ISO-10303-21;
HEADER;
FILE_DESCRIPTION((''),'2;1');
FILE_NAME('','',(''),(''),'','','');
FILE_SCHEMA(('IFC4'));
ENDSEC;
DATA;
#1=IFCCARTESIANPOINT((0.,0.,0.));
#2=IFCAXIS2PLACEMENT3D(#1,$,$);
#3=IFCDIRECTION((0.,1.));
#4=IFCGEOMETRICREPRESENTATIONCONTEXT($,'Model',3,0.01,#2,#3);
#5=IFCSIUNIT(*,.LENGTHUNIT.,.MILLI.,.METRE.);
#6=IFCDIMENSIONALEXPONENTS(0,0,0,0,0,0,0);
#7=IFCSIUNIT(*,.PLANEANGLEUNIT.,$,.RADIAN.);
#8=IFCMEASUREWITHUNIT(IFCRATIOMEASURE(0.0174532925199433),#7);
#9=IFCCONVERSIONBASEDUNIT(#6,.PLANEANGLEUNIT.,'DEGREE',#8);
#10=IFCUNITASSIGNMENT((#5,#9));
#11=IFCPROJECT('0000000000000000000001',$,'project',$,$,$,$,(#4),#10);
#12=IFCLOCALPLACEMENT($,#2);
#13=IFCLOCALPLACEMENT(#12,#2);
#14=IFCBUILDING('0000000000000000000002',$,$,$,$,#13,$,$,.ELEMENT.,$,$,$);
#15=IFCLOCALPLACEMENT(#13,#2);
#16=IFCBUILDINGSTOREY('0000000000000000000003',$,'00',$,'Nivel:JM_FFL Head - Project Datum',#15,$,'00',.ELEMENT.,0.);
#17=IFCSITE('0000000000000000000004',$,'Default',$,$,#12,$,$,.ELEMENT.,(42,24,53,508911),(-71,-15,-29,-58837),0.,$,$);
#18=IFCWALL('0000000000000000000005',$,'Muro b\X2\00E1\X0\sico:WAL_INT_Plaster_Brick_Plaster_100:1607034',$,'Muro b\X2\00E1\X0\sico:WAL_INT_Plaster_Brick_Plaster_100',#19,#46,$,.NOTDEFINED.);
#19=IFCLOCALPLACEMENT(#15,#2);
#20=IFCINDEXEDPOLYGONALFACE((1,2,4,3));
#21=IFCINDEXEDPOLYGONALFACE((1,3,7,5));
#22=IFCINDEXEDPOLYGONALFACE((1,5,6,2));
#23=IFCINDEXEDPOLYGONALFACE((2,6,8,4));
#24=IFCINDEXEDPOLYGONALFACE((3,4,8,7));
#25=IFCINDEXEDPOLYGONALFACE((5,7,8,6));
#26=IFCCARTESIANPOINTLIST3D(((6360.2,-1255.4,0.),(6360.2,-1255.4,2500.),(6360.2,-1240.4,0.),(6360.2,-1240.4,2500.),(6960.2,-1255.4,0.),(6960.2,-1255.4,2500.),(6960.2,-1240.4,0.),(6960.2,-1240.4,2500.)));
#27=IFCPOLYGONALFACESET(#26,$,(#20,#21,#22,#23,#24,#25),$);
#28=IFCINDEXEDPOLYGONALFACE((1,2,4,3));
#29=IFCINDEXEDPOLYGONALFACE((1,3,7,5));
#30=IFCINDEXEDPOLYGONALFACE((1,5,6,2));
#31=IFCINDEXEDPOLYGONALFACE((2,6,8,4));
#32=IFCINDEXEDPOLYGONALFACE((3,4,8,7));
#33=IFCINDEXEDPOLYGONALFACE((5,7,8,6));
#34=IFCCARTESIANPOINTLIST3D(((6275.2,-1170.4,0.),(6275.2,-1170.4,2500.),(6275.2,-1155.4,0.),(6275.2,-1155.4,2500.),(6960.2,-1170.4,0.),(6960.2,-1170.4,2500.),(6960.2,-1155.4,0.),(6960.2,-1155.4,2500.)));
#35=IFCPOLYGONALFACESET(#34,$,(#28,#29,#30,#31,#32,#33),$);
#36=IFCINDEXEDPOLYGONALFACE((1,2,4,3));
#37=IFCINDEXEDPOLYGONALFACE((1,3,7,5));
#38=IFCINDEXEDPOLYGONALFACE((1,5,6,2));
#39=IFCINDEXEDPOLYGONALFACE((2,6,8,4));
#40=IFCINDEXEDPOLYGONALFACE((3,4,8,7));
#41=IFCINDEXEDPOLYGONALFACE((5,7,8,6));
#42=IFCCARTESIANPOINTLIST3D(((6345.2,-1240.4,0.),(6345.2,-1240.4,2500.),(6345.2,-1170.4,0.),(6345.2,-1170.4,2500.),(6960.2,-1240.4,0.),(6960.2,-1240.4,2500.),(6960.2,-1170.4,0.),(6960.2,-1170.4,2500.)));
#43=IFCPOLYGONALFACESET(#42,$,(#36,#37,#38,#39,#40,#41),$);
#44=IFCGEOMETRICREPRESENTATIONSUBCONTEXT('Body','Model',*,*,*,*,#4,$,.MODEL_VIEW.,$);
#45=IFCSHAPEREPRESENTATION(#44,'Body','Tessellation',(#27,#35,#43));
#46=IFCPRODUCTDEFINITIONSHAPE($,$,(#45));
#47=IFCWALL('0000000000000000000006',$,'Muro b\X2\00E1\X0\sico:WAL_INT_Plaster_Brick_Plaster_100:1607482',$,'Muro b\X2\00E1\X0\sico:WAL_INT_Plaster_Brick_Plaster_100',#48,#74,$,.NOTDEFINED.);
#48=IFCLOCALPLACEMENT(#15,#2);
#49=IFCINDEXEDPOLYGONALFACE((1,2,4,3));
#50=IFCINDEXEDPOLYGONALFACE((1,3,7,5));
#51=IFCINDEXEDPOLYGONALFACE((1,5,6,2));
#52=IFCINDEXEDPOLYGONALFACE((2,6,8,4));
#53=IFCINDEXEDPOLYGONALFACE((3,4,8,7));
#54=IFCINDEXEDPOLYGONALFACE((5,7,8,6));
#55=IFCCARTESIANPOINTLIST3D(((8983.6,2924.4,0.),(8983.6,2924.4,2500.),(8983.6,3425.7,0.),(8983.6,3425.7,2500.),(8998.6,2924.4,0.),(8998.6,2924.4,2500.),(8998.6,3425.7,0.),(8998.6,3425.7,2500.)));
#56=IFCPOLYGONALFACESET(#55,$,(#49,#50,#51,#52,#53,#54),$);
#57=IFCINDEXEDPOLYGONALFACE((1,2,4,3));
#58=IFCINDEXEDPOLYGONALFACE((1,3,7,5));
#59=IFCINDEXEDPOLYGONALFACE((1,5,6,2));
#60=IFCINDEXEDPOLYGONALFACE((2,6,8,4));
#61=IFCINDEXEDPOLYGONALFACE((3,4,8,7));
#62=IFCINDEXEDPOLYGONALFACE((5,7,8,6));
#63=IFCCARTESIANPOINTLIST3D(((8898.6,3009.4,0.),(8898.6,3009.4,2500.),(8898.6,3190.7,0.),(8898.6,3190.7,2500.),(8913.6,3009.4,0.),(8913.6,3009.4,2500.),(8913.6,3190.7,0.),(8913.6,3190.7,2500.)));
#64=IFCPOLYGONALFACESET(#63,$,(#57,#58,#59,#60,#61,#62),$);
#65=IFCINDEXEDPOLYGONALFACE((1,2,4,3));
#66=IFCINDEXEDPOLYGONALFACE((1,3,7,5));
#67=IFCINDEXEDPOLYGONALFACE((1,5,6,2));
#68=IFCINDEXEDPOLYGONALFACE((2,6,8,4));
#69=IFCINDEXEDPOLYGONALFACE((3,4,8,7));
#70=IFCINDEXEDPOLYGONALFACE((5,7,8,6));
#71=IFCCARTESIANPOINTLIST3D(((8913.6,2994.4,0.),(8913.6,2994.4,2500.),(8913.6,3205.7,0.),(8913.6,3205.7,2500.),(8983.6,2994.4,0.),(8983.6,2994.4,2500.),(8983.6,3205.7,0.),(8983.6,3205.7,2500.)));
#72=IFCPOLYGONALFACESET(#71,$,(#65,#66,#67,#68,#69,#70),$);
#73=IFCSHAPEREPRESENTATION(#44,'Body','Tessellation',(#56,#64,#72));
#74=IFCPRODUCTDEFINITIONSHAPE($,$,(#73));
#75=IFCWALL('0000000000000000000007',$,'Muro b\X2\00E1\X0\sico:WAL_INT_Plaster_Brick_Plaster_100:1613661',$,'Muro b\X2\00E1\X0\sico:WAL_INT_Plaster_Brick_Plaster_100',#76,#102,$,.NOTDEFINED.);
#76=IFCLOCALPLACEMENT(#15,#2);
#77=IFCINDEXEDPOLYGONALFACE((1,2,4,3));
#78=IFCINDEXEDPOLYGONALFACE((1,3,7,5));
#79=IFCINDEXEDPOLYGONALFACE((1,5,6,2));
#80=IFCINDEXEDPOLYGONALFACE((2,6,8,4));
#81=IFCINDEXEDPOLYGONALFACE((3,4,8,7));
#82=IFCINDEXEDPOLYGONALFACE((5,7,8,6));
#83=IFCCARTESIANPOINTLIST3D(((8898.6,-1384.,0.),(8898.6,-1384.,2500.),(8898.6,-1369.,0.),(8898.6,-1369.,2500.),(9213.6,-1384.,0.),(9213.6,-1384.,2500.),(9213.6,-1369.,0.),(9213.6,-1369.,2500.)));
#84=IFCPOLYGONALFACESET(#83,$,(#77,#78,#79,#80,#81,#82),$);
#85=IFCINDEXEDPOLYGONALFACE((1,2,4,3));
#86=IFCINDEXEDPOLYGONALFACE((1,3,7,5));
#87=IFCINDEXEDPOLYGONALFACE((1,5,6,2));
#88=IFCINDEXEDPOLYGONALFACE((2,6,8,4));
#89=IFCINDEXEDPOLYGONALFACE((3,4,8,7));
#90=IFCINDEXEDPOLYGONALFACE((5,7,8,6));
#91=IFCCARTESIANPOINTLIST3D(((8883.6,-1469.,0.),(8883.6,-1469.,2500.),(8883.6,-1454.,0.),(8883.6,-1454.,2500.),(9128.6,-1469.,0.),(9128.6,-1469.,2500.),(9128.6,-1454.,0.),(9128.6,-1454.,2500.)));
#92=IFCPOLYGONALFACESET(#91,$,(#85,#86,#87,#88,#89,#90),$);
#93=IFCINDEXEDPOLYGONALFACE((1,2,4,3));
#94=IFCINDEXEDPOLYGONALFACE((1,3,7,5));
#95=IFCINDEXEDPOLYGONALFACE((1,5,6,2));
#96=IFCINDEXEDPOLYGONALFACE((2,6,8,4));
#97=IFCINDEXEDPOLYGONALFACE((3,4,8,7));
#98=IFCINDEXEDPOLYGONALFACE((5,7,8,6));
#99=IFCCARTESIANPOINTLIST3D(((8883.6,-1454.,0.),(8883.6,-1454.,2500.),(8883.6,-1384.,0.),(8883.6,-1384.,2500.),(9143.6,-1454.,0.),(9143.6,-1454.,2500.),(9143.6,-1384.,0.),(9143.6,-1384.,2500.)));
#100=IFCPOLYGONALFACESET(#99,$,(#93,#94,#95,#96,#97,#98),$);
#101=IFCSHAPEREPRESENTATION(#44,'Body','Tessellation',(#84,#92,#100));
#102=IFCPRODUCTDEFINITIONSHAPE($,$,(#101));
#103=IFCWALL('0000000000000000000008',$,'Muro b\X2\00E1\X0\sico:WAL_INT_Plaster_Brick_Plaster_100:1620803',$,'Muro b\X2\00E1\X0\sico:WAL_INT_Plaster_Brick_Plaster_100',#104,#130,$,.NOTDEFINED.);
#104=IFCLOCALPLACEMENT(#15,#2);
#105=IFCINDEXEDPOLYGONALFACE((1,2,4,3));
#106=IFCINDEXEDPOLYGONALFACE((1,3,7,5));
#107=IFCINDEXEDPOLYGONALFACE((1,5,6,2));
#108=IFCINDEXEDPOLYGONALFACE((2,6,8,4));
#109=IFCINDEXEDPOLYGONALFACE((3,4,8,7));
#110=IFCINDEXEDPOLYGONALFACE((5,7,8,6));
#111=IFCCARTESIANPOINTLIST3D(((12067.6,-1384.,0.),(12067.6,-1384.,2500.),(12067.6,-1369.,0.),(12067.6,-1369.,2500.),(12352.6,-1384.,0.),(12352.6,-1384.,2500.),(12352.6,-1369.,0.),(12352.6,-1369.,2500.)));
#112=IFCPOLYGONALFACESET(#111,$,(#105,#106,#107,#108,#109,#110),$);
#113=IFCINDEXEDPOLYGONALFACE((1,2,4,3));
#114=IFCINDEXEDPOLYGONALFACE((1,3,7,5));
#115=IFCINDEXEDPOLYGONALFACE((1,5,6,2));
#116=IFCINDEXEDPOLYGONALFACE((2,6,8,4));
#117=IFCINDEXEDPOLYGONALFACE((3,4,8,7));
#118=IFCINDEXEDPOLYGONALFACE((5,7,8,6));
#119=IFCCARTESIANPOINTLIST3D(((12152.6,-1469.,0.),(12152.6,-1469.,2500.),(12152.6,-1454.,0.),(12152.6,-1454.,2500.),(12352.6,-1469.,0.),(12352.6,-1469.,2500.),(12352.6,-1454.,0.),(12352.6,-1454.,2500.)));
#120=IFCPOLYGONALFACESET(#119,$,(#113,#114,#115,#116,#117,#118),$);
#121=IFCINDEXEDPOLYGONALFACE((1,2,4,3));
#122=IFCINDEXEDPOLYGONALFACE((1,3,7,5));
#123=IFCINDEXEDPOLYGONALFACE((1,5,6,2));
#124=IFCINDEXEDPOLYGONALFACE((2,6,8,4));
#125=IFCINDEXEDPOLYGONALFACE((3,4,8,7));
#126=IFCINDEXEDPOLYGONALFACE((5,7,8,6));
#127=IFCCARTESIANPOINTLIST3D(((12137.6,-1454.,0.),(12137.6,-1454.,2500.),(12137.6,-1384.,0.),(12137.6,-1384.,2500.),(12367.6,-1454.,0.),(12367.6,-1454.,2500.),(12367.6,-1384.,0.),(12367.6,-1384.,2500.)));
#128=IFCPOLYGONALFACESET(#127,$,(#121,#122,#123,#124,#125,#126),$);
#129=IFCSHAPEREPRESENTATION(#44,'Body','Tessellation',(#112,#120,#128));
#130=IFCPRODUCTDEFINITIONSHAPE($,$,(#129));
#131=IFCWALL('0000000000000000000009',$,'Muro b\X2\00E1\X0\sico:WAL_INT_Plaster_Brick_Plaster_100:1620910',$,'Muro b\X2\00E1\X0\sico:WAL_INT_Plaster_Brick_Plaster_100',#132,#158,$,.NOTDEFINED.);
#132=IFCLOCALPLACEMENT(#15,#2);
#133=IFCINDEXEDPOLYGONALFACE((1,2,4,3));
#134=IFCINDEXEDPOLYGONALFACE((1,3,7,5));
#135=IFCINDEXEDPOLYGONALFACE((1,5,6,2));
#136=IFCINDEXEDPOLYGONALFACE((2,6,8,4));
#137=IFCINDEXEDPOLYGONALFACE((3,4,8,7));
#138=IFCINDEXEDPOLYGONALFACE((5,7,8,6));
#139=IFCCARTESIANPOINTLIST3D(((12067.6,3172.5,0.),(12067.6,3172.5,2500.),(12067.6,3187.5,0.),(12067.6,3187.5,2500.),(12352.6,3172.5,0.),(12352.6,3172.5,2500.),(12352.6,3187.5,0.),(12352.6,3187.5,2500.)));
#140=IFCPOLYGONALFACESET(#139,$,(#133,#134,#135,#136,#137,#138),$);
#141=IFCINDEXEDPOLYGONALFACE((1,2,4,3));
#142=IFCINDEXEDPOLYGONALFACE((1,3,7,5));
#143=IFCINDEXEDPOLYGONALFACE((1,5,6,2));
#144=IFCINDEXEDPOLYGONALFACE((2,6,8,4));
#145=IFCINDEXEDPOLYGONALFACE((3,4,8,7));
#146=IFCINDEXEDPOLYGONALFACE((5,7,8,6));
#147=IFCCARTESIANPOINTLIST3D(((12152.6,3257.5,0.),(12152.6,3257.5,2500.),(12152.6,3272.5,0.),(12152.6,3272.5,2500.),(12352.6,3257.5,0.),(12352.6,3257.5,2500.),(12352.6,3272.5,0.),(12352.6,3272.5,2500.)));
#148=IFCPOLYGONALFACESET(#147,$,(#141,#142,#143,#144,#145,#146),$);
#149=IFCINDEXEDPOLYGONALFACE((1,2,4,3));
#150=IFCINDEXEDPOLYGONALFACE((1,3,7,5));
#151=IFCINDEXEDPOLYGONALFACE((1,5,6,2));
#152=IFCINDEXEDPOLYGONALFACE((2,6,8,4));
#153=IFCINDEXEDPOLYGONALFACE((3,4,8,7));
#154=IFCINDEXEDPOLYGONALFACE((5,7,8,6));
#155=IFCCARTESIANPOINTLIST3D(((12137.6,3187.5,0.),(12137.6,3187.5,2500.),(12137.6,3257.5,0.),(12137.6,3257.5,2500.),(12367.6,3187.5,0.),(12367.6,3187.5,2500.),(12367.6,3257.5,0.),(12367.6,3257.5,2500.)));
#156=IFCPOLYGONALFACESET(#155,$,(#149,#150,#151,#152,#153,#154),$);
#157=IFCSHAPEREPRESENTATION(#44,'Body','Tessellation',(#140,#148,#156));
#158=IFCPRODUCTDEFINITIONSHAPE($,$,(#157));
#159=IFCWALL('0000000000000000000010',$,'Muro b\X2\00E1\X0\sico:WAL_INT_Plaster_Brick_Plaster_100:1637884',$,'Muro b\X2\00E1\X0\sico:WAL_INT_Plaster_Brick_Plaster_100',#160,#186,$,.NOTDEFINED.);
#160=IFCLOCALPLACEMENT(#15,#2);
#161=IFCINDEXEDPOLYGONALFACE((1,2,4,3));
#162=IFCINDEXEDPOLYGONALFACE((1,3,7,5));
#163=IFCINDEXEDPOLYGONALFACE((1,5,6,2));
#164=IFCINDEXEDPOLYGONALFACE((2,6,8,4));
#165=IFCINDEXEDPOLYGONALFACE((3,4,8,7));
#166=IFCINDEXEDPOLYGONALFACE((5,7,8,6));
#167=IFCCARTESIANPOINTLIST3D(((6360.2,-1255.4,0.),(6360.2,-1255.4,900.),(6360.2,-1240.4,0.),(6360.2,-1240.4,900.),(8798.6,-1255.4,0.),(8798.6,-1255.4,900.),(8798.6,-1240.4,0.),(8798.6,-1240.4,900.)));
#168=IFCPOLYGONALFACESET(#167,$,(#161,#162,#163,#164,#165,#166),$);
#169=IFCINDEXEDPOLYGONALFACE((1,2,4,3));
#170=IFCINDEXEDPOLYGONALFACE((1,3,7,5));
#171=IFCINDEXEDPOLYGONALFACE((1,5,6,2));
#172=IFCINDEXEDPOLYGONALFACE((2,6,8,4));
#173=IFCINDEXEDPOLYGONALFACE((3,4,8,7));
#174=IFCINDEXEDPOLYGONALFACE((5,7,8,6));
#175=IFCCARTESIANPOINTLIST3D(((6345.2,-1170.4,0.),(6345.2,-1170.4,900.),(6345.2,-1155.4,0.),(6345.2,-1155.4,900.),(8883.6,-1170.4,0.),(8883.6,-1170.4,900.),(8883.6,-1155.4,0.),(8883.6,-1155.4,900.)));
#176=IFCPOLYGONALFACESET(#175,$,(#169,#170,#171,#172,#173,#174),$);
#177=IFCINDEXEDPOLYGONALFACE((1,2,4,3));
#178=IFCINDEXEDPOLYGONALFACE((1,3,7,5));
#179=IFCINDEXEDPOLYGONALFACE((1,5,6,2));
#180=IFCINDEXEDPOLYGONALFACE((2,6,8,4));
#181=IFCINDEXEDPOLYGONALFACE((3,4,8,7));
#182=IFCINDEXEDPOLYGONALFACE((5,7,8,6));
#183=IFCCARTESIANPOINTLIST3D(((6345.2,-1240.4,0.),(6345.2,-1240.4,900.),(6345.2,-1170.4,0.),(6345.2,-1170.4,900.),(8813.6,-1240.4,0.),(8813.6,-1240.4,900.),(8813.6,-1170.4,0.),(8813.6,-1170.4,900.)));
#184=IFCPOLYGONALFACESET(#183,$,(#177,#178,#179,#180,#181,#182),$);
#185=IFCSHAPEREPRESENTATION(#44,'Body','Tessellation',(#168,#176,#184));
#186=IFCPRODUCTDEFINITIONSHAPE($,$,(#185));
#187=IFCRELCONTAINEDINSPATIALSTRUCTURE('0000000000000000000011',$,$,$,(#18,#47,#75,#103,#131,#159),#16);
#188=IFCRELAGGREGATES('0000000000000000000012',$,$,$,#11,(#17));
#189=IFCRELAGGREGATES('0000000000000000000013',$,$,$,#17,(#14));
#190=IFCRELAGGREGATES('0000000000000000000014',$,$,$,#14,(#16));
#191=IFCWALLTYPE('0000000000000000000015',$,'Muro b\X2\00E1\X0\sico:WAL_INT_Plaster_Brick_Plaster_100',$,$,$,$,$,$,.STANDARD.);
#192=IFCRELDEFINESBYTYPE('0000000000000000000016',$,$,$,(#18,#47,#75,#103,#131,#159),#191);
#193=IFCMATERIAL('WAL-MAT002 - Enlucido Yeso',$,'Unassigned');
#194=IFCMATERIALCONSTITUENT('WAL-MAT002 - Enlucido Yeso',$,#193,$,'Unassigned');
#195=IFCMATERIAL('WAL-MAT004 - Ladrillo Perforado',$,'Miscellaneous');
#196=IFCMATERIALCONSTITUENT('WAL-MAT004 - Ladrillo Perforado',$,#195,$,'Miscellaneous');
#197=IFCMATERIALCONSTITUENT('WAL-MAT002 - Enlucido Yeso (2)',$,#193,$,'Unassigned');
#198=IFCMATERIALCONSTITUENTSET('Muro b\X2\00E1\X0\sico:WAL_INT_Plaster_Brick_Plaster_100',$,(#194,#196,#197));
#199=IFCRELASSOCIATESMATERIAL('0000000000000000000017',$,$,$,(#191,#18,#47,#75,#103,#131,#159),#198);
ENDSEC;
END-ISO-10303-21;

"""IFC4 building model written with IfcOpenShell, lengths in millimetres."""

from ifc_helpers import new_model, entity, si_unit, converted_unit, direction, frame, origin, place, context, subcontext, project, spatial, indexed_curve, outline, extrude, material, constituent, constituent_set, type_object, element, save


model = new_model("IFC4")

# Units and contexts
model_context = context("Model", 3, precision=0.01, world=origin(), true_north=direction((0.0, 1.0)))
body_context = subcontext(model_context, "Body", "Model", "MODEL_VIEW")
ifc_project = project(units=[si_unit("LENGTHUNIT", "METRE", prefix="MILLI"), converted_unit("PLANEANGLEUNIT", "DEGREE", entity("IfcRatioMeasure", 0.0174532925199433), si_unit("PLANEANGLEUNIT", "RADIAN"), dimensions=[0, 0, 0, 0, 0, 0, 0])], contexts=[model_context])

# Site, building, storey
site_placement = place(None, origin())
site = spatial("IfcSite", under=ifc_project, at=site_placement, Name="Default", CompositionType="ELEMENT", RefLatitude=(42, 24, 53, 508911), RefLongitude=(-71, -15, -29, -58837), RefElevation=0.0)
building_placement = place(site_placement, origin())
building = spatial("IfcBuilding", under=site, at=building_placement, CompositionType="ELEMENT")
storey_placement = place(building_placement, origin())
storey = spatial("IfcBuildingStorey", under=building, at=storey_placement, Name="00", ObjectType="Nivel:JM_FFL Head - Project Datum", LongName="00", CompositionType="ELEMENT", Elevation=0.0)

# Walls
ifc_material_1 = material(Name="WAL-MAT002 - Enlucido Yeso", Category="Unassigned")
ifc_constituent_1 = constituent(ifc_material_1, Name="WAL-MAT002 - Enlucido Yeso", Category="Unassigned")
ifc_material_2 = material(Name="WAL-MAT004 - Ladrillo Perforado", Category="Miscellaneous")
ifc_constituent_2 = constituent(ifc_material_2, Name="WAL-MAT004 - Ladrillo Perforado", Category="Miscellaneous")
ifc_constituent_3 = constituent(ifc_material_1, Name="WAL-MAT002 - Enlucido Yeso (2)", Category="Unassigned")
ifc_constituent_set_1 = constituent_set(constituents=[ifc_constituent_1, ifc_constituent_2, ifc_constituent_3], Name="Muro básico:WAL_INT_Plaster_Brick_Plaster_100")
wall_type = type_object("IfcWallType", Name="Muro básico:WAL_INT_Plaster_Brick_Plaster_100", PredefinedType="STANDARD", material=ifc_constituent_set_1)
wall_1_placement = place(storey_placement, frame((6360.2, -1205.4, 0.0)))
element("IfcWall", 1, at=wall_1_placement, inside=storey, type_object=wall_type, material=ifc_constituent_set_1, Name="Muro básico:WAL_INT_Plaster_Brick_Plaster_100:1607034", ObjectType="Muro básico:WAL_INT_Plaster_Brick_Plaster_100", PredefinedType="NOTDEFINED", context=body_context, shape_type="SweptSolid", body=[
    extrude(outline(indexed_curve([(-7.5, -300.0), (7.5, -300.0), (7.5, 300.0), (-7.5, 300.0), (-7.5, -300.0)], self_intersect=False)), frame((300.0, -42.5, 0.0), z_axis=(0.0, 0.0, 1.0), x_axis=(0.0, 1.0, 0.0)), (0.0, 0.0, 1.0), 2500.0),
    extrude(outline(indexed_curve([(-7.5, -342.5), (7.5, -342.5), (7.5, 342.5), (-7.5, 342.5), (-7.5, -342.5)], self_intersect=False)), frame((257.5, 42.5, 0.0), z_axis=(0.0, 0.0, 1.0), x_axis=(0.0, -1.0, 0.0)), (0.0, 0.0, 1.0), 2500.0),
    extrude(outline(indexed_curve([(-307.5, -35.0), (307.5, -35.0), (307.5, 35.0), (-307.5, 35.0), (-307.5, -35.0)], self_intersect=False)), frame((292.5, 0.0, 0.0)), (0.0, 0.0, 1.0), 2500.0),
])
wall_2_placement = place(storey_placement, frame((8948.6, 3009.4, 0.0), z_axis=(0.0, 0.0, 1.0), x_axis=(0.0, 1.0, 0.0)))
element("IfcWall", 2, at=wall_2_placement, inside=storey, type_object=wall_type, material=ifc_constituent_set_1, Name="Muro básico:WAL_INT_Plaster_Brick_Plaster_100:1607482", ObjectType="Muro básico:WAL_INT_Plaster_Brick_Plaster_100", PredefinedType="NOTDEFINED", context=body_context, shape_type="SweptSolid", body=[
    extrude(outline(indexed_curve([(-7.5, -250.6), (7.5, -250.6), (7.5, 250.6), (-7.5, 250.6), (-7.5, -250.6)], self_intersect=False)), frame((165.6, -42.5, 0.0), z_axis=(0.0, 0.0, 1.0), x_axis=(0.0, 1.0, 0.0)), (0.0, 0.0, 1.0), 2500.0),
    extrude(outline(indexed_curve([(-7.5, -90.6), (7.5, -90.6), (7.5, 90.6), (-7.5, 90.6), (-7.5, -90.6)], self_intersect=False)), frame((90.6, 42.5, 0.0), z_axis=(0.0, 0.0, 1.0), x_axis=(0.0, -1.0, 0.0)), (0.0, 0.0, 1.0), 2500.0),
    extrude(outline(indexed_curve([(-35.0, -105.6), (35.0, -105.6), (35.0, 105.6), (-35.0, 105.6), (-35.0, -105.6)], self_intersect=False)), frame((90.6, 0.0, 0.0), z_axis=(0.0, 0.0, 1.0), x_axis=(0.0, -1.0, 0.0)), (0.0, 0.0, 1.0), 2500.0),
])
wall_3_placement = place(storey_placement, frame((9128.6, -1419.0, 0.0), z_axis=(0.0, 0.0, 1.0), x_axis=(-1.0, 0.0, 0.0)))
element("IfcWall", 3, at=wall_3_placement, inside=storey, type_object=wall_type, material=ifc_constituent_set_1, Name="Muro básico:WAL_INT_Plaster_Brick_Plaster_100:1613661", ObjectType="Muro básico:WAL_INT_Plaster_Brick_Plaster_100", PredefinedType="NOTDEFINED", context=body_context, shape_type="SweptSolid", body=[
    extrude(outline(indexed_curve([(-7.5, -157.5), (7.5, -157.5), (7.5, 157.5), (-7.5, 157.5), (-7.5, -157.5)], self_intersect=False)), frame((72.5, -42.5, 0.0), z_axis=(0.0, 0.0, 1.0), x_axis=(0.0, 1.0, 0.0)), (0.0, 0.0, 1.0), 2500.0),
    extrude(outline(indexed_curve([(-7.5, -122.5), (7.5, -122.5), (7.5, 122.5), (-7.5, 122.5), (-7.5, -122.5)], self_intersect=False)), frame((122.5, 42.5, 0.0), z_axis=(0.0, 0.0, 1.0), x_axis=(0.0, -1.0, 0.0)), (0.0, 0.0, 1.0), 2500.0),
    extrude(outline(indexed_curve([(-130.0, -35.0), (130.0, -35.0), (130.0, 35.0), (-130.0, 35.0), (-130.0, -35.0)], self_intersect=False)), frame((115.0, 0.0, 0.0)), (0.0, 0.0, 1.0), 2500.0),
])
wall_4_placement = place(storey_placement, frame((12152.6, -1419.0, 0.0)))
element("IfcWall", 4, at=wall_4_placement, inside=storey, type_object=wall_type, material=ifc_constituent_set_1, Name="Muro básico:WAL_INT_Plaster_Brick_Plaster_100:1620803", ObjectType="Muro básico:WAL_INT_Plaster_Brick_Plaster_100", PredefinedType="NOTDEFINED", context=body_context, shape_type="SweptSolid", body=[
    extrude(outline(indexed_curve([(-7.5, -142.5), (7.5, -142.5), (7.5, 142.5), (-7.5, 142.5), (-7.5, -142.5)], self_intersect=False)), frame((57.5, 42.5, 0.0), z_axis=(0.0, 0.0, 1.0), x_axis=(0.0, -1.0, 0.0)), (0.0, 0.0, 1.0), 2500.0),
    extrude(outline(indexed_curve([(-7.5, -100.0), (7.5, -100.0), (7.5, 100.0), (-7.5, 100.0), (-7.5, -100.0)], self_intersect=False)), frame((100.0, -42.5, 0.0), z_axis=(0.0, 0.0, 1.0), x_axis=(0.0, 1.0, 0.0)), (0.0, 0.0, 1.0), 2500.0),
    extrude(outline(indexed_curve([(-115.0, -35.0), (115.0, -35.0), (115.0, 35.0), (-115.0, 35.0), (-115.0, -35.0)], self_intersect=False)), frame((100.0, 0.0, 0.0)), (0.0, 0.0, 1.0), 2500.0),
])
wall_5_placement = place(storey_placement, frame((12152.6, 3222.5, 0.0)))
element("IfcWall", 5, at=wall_5_placement, inside=storey, type_object=wall_type, material=ifc_constituent_set_1, Name="Muro básico:WAL_INT_Plaster_Brick_Plaster_100:1620910", ObjectType="Muro básico:WAL_INT_Plaster_Brick_Plaster_100", PredefinedType="NOTDEFINED", context=body_context, shape_type="SweptSolid", body=[
    extrude(outline(indexed_curve([(-7.5, -142.5), (7.5, -142.5), (7.5, 142.5), (-7.5, 142.5), (-7.5, -142.5)], self_intersect=False)), frame((57.5, -42.5, 0.0), z_axis=(0.0, 0.0, 1.0), x_axis=(0.0, 1.0, 0.0)), (0.0, 0.0, 1.0), 2500.0),
    extrude(outline(indexed_curve([(-7.5, -100.0), (7.5, -100.0), (7.5, 100.0), (-7.5, 100.0), (-7.5, -100.0)], self_intersect=False)), frame((100.0, 42.5, 0.0), z_axis=(0.0, 0.0, 1.0), x_axis=(0.0, -1.0, 0.0)), (0.0, 0.0, 1.0), 2500.0),
    extrude(outline(indexed_curve([(-115.0, -35.0), (115.0, -35.0), (115.0, 35.0), (-115.0, 35.0), (-115.0, -35.0)], self_intersect=False)), frame((100.0, 0.0, 0.0)), (0.0, 0.0, 1.0), 2500.0),
])
wall_6_placement = place(storey_placement, frame((6360.2, -1205.4, 0.0)))
element("IfcWall", 6, at=wall_6_placement, inside=storey, type_object=wall_type, material=ifc_constituent_set_1, Name="Muro básico:WAL_INT_Plaster_Brick_Plaster_100:1637884", ObjectType="Muro básico:WAL_INT_Plaster_Brick_Plaster_100", PredefinedType="NOTDEFINED", context=body_context, shape_type="SweptSolid", body=[
    extrude(outline(indexed_curve([(-7.5, -1219.2), (7.5, -1219.2), (7.5, 1219.2), (-7.5, 1219.2), (-7.5, -1219.2)], self_intersect=False)), frame((1219.2, -42.5, 0.0), z_axis=(0.0, 0.0, 1.0), x_axis=(0.0, 1.0, 0.0)), (0.0, 0.0, 1.0), 900.0),
    extrude(outline(indexed_curve([(-7.5, -1269.2), (7.5, -1269.2), (7.5, 1269.2), (-7.5, 1269.2), (-7.5, -1269.2)], self_intersect=False)), frame((1254.2, 42.5, 0.0), z_axis=(0.0, 0.0, 1.0), x_axis=(0.0, -1.0, 0.0)), (0.0, 0.0, 1.0), 900.0),
    extrude(outline(indexed_curve([(-1234.2, -35.0), (1234.2, -35.0), (1234.2, 35.0), (-1234.2, 35.0), (-1234.2, -35.0)], self_intersect=False)), frame((1219.2, 0.0, 0.0)), (0.0, 0.0, 1.0), 900.0),
])

save(model, "model.ifc")
